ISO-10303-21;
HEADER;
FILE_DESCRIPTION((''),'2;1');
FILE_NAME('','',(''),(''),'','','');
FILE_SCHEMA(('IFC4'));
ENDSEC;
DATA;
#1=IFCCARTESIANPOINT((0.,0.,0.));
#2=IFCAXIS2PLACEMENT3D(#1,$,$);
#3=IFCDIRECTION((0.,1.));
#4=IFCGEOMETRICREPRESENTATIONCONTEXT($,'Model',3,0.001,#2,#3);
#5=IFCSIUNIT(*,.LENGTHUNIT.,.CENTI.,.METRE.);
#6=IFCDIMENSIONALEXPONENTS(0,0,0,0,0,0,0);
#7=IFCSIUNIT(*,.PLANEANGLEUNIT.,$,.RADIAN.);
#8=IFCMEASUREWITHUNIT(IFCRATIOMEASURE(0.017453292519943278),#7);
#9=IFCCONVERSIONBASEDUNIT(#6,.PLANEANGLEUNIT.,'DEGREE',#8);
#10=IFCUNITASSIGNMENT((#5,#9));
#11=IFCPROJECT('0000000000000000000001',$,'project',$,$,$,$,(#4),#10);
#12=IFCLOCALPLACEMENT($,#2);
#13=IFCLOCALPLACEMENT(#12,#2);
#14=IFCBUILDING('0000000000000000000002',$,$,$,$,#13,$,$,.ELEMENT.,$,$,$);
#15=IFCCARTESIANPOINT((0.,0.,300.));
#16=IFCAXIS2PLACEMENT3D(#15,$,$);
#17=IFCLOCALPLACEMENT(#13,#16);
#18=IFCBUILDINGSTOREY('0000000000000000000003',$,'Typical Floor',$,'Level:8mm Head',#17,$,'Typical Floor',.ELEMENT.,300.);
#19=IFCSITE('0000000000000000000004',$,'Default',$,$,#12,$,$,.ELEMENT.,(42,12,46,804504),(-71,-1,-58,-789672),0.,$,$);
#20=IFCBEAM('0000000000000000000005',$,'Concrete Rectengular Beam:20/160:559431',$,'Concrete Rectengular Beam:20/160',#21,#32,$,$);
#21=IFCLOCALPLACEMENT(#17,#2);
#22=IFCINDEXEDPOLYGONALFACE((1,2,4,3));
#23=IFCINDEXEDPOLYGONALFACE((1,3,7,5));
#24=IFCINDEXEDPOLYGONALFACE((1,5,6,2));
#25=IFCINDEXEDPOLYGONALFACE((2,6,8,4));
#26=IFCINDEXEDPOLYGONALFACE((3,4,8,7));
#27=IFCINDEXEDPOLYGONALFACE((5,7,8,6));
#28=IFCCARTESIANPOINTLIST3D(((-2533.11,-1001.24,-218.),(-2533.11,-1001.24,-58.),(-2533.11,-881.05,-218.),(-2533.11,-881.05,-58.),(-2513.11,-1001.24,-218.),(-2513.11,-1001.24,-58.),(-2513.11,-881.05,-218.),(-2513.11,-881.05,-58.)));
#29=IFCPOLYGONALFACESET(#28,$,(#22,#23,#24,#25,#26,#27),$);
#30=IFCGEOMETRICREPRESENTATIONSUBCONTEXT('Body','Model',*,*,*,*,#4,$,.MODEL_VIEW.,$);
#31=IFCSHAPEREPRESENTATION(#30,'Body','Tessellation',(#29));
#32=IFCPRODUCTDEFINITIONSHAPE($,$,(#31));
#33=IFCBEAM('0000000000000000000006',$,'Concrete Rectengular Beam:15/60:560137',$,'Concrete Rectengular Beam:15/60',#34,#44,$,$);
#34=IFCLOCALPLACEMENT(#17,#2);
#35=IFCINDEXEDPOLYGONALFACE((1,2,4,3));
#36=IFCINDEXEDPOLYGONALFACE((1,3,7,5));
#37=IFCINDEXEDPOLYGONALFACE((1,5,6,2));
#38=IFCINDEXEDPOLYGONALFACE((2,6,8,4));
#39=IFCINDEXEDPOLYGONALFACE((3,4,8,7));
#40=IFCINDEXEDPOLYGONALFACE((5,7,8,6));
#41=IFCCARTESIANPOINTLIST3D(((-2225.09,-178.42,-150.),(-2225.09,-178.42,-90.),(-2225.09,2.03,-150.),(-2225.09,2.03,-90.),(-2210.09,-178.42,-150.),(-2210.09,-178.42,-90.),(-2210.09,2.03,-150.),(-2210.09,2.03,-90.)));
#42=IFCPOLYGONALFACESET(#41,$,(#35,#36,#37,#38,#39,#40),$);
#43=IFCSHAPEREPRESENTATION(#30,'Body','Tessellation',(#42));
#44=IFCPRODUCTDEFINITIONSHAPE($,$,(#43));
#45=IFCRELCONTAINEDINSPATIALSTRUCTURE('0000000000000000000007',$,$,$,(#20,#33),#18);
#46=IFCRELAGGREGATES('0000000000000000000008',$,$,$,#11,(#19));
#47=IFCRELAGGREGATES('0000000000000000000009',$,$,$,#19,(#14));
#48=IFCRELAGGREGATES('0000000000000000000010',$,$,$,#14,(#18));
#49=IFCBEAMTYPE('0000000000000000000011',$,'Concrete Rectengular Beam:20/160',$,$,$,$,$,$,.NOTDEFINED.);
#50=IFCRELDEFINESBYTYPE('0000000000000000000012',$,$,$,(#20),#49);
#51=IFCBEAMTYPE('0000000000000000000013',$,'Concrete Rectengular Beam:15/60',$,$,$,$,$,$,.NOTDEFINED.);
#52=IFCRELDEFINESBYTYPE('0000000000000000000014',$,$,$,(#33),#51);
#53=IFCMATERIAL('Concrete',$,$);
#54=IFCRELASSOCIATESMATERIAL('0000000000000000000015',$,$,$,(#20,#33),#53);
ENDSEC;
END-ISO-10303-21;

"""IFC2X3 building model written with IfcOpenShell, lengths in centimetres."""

from ifc_helpers import new_model, entity, si_unit, converted_unit, direction, frame, frame_2d, origin, place, context, subcontext, project, spatial, rectangle, extrude, material, type_object, element, save


model = new_model("IFC2X3")

# Units and contexts
model_context = context("Model", 3, precision=0.001, world=origin(), true_north=direction((0.0, 1.0)))
body_context = subcontext(model_context, "Body", "Model", "MODEL_VIEW")
ifc_project = project(units=[si_unit("LENGTHUNIT", "METRE", prefix="CENTI"), converted_unit("PLANEANGLEUNIT", "DEGREE", entity("IfcRatioMeasure", 0.017453292519943278), si_unit("PLANEANGLEUNIT", "RADIAN"), dimensions=[0, 0, 0, 0, 0, 0, 0])], contexts=[model_context])

# Site, building, storey
site_placement = place(None, origin())
site = spatial("IfcSite", under=ifc_project, at=site_placement, Name="Default", CompositionType="ELEMENT", RefLatitude=(42, 12, 46, 804504), RefLongitude=(-71, -1, -58, -789672), RefElevation=0.0)
building_placement = place(site_placement, origin())
building = spatial("IfcBuilding", under=site, at=building_placement, CompositionType="ELEMENT")
storey_placement = place(building_placement, frame((0.0, 0.0, 300.0)))
storey = spatial("IfcBuildingStorey", under=building, at=storey_placement, Name="Typical Floor", ObjectType="Level:8mm Head", LongName="Typical Floor", CompositionType="ELEMENT", Elevation=300.0)

# Beams
ifc_material = material(Name="Concrete")
beam_type_1 = type_object("IfcBeamType", Name="Concrete Rectengular Beam:20/160", PredefinedType="NOTDEFINED")
beam_1_placement = place(storey_placement, frame((-2523.11, -1011.24, 0.0), z_axis=(0.0, 0.0, 1.0), x_axis=(0.0, 1.0, 0.0)))
element("IfcBeam", 1, at=beam_1_placement, inside=storey, type_object=beam_type_1, material=ifc_material, Name="Concrete Rectengular Beam:20/160:559431", ObjectType="Concrete Rectengular Beam:20/160", context=body_context, shape_type="SweptSolid", body=[
    extrude(rectangle(XDim=160.0, YDim=20.0, at=frame_2d((0.0, 0.0), x_axis=(1.0, 0.0))), frame((10.0, 0.0, -138.0), z_axis=(1.0, 0.0, 0.0), x_axis=(0.0, 0.0, -1.0)), (0.0, 0.0, 1.0), 120.19),
])
beam_type_2 = type_object("IfcBeamType", Name="Concrete Rectengular Beam:15/60", PredefinedType="NOTDEFINED")
beam_2_placement = place(storey_placement, frame((-2217.59, 9.53, 0.0), z_axis=(0.0, 0.0, 1.0), x_axis=(0.0, -1.0, 0.0)))
element("IfcBeam", 2, at=beam_2_placement, inside=storey, type_object=beam_type_2, material=ifc_material, Name="Concrete Rectengular Beam:15/60:560137", ObjectType="Concrete Rectengular Beam:15/60", context=body_context, shape_type="SweptSolid", body=[
    extrude(rectangle(XDim=60.0, YDim=15.0, at=frame_2d((0.0, 0.0), x_axis=(1.0, 0.0))), frame((7.5, 0.0, -120.0), z_axis=(1.0, 0.0, 0.0), x_axis=(0.0, 0.0, -1.0)), (0.0, 0.0, 1.0), 180.45),
])

save(model, "model.ifc")
